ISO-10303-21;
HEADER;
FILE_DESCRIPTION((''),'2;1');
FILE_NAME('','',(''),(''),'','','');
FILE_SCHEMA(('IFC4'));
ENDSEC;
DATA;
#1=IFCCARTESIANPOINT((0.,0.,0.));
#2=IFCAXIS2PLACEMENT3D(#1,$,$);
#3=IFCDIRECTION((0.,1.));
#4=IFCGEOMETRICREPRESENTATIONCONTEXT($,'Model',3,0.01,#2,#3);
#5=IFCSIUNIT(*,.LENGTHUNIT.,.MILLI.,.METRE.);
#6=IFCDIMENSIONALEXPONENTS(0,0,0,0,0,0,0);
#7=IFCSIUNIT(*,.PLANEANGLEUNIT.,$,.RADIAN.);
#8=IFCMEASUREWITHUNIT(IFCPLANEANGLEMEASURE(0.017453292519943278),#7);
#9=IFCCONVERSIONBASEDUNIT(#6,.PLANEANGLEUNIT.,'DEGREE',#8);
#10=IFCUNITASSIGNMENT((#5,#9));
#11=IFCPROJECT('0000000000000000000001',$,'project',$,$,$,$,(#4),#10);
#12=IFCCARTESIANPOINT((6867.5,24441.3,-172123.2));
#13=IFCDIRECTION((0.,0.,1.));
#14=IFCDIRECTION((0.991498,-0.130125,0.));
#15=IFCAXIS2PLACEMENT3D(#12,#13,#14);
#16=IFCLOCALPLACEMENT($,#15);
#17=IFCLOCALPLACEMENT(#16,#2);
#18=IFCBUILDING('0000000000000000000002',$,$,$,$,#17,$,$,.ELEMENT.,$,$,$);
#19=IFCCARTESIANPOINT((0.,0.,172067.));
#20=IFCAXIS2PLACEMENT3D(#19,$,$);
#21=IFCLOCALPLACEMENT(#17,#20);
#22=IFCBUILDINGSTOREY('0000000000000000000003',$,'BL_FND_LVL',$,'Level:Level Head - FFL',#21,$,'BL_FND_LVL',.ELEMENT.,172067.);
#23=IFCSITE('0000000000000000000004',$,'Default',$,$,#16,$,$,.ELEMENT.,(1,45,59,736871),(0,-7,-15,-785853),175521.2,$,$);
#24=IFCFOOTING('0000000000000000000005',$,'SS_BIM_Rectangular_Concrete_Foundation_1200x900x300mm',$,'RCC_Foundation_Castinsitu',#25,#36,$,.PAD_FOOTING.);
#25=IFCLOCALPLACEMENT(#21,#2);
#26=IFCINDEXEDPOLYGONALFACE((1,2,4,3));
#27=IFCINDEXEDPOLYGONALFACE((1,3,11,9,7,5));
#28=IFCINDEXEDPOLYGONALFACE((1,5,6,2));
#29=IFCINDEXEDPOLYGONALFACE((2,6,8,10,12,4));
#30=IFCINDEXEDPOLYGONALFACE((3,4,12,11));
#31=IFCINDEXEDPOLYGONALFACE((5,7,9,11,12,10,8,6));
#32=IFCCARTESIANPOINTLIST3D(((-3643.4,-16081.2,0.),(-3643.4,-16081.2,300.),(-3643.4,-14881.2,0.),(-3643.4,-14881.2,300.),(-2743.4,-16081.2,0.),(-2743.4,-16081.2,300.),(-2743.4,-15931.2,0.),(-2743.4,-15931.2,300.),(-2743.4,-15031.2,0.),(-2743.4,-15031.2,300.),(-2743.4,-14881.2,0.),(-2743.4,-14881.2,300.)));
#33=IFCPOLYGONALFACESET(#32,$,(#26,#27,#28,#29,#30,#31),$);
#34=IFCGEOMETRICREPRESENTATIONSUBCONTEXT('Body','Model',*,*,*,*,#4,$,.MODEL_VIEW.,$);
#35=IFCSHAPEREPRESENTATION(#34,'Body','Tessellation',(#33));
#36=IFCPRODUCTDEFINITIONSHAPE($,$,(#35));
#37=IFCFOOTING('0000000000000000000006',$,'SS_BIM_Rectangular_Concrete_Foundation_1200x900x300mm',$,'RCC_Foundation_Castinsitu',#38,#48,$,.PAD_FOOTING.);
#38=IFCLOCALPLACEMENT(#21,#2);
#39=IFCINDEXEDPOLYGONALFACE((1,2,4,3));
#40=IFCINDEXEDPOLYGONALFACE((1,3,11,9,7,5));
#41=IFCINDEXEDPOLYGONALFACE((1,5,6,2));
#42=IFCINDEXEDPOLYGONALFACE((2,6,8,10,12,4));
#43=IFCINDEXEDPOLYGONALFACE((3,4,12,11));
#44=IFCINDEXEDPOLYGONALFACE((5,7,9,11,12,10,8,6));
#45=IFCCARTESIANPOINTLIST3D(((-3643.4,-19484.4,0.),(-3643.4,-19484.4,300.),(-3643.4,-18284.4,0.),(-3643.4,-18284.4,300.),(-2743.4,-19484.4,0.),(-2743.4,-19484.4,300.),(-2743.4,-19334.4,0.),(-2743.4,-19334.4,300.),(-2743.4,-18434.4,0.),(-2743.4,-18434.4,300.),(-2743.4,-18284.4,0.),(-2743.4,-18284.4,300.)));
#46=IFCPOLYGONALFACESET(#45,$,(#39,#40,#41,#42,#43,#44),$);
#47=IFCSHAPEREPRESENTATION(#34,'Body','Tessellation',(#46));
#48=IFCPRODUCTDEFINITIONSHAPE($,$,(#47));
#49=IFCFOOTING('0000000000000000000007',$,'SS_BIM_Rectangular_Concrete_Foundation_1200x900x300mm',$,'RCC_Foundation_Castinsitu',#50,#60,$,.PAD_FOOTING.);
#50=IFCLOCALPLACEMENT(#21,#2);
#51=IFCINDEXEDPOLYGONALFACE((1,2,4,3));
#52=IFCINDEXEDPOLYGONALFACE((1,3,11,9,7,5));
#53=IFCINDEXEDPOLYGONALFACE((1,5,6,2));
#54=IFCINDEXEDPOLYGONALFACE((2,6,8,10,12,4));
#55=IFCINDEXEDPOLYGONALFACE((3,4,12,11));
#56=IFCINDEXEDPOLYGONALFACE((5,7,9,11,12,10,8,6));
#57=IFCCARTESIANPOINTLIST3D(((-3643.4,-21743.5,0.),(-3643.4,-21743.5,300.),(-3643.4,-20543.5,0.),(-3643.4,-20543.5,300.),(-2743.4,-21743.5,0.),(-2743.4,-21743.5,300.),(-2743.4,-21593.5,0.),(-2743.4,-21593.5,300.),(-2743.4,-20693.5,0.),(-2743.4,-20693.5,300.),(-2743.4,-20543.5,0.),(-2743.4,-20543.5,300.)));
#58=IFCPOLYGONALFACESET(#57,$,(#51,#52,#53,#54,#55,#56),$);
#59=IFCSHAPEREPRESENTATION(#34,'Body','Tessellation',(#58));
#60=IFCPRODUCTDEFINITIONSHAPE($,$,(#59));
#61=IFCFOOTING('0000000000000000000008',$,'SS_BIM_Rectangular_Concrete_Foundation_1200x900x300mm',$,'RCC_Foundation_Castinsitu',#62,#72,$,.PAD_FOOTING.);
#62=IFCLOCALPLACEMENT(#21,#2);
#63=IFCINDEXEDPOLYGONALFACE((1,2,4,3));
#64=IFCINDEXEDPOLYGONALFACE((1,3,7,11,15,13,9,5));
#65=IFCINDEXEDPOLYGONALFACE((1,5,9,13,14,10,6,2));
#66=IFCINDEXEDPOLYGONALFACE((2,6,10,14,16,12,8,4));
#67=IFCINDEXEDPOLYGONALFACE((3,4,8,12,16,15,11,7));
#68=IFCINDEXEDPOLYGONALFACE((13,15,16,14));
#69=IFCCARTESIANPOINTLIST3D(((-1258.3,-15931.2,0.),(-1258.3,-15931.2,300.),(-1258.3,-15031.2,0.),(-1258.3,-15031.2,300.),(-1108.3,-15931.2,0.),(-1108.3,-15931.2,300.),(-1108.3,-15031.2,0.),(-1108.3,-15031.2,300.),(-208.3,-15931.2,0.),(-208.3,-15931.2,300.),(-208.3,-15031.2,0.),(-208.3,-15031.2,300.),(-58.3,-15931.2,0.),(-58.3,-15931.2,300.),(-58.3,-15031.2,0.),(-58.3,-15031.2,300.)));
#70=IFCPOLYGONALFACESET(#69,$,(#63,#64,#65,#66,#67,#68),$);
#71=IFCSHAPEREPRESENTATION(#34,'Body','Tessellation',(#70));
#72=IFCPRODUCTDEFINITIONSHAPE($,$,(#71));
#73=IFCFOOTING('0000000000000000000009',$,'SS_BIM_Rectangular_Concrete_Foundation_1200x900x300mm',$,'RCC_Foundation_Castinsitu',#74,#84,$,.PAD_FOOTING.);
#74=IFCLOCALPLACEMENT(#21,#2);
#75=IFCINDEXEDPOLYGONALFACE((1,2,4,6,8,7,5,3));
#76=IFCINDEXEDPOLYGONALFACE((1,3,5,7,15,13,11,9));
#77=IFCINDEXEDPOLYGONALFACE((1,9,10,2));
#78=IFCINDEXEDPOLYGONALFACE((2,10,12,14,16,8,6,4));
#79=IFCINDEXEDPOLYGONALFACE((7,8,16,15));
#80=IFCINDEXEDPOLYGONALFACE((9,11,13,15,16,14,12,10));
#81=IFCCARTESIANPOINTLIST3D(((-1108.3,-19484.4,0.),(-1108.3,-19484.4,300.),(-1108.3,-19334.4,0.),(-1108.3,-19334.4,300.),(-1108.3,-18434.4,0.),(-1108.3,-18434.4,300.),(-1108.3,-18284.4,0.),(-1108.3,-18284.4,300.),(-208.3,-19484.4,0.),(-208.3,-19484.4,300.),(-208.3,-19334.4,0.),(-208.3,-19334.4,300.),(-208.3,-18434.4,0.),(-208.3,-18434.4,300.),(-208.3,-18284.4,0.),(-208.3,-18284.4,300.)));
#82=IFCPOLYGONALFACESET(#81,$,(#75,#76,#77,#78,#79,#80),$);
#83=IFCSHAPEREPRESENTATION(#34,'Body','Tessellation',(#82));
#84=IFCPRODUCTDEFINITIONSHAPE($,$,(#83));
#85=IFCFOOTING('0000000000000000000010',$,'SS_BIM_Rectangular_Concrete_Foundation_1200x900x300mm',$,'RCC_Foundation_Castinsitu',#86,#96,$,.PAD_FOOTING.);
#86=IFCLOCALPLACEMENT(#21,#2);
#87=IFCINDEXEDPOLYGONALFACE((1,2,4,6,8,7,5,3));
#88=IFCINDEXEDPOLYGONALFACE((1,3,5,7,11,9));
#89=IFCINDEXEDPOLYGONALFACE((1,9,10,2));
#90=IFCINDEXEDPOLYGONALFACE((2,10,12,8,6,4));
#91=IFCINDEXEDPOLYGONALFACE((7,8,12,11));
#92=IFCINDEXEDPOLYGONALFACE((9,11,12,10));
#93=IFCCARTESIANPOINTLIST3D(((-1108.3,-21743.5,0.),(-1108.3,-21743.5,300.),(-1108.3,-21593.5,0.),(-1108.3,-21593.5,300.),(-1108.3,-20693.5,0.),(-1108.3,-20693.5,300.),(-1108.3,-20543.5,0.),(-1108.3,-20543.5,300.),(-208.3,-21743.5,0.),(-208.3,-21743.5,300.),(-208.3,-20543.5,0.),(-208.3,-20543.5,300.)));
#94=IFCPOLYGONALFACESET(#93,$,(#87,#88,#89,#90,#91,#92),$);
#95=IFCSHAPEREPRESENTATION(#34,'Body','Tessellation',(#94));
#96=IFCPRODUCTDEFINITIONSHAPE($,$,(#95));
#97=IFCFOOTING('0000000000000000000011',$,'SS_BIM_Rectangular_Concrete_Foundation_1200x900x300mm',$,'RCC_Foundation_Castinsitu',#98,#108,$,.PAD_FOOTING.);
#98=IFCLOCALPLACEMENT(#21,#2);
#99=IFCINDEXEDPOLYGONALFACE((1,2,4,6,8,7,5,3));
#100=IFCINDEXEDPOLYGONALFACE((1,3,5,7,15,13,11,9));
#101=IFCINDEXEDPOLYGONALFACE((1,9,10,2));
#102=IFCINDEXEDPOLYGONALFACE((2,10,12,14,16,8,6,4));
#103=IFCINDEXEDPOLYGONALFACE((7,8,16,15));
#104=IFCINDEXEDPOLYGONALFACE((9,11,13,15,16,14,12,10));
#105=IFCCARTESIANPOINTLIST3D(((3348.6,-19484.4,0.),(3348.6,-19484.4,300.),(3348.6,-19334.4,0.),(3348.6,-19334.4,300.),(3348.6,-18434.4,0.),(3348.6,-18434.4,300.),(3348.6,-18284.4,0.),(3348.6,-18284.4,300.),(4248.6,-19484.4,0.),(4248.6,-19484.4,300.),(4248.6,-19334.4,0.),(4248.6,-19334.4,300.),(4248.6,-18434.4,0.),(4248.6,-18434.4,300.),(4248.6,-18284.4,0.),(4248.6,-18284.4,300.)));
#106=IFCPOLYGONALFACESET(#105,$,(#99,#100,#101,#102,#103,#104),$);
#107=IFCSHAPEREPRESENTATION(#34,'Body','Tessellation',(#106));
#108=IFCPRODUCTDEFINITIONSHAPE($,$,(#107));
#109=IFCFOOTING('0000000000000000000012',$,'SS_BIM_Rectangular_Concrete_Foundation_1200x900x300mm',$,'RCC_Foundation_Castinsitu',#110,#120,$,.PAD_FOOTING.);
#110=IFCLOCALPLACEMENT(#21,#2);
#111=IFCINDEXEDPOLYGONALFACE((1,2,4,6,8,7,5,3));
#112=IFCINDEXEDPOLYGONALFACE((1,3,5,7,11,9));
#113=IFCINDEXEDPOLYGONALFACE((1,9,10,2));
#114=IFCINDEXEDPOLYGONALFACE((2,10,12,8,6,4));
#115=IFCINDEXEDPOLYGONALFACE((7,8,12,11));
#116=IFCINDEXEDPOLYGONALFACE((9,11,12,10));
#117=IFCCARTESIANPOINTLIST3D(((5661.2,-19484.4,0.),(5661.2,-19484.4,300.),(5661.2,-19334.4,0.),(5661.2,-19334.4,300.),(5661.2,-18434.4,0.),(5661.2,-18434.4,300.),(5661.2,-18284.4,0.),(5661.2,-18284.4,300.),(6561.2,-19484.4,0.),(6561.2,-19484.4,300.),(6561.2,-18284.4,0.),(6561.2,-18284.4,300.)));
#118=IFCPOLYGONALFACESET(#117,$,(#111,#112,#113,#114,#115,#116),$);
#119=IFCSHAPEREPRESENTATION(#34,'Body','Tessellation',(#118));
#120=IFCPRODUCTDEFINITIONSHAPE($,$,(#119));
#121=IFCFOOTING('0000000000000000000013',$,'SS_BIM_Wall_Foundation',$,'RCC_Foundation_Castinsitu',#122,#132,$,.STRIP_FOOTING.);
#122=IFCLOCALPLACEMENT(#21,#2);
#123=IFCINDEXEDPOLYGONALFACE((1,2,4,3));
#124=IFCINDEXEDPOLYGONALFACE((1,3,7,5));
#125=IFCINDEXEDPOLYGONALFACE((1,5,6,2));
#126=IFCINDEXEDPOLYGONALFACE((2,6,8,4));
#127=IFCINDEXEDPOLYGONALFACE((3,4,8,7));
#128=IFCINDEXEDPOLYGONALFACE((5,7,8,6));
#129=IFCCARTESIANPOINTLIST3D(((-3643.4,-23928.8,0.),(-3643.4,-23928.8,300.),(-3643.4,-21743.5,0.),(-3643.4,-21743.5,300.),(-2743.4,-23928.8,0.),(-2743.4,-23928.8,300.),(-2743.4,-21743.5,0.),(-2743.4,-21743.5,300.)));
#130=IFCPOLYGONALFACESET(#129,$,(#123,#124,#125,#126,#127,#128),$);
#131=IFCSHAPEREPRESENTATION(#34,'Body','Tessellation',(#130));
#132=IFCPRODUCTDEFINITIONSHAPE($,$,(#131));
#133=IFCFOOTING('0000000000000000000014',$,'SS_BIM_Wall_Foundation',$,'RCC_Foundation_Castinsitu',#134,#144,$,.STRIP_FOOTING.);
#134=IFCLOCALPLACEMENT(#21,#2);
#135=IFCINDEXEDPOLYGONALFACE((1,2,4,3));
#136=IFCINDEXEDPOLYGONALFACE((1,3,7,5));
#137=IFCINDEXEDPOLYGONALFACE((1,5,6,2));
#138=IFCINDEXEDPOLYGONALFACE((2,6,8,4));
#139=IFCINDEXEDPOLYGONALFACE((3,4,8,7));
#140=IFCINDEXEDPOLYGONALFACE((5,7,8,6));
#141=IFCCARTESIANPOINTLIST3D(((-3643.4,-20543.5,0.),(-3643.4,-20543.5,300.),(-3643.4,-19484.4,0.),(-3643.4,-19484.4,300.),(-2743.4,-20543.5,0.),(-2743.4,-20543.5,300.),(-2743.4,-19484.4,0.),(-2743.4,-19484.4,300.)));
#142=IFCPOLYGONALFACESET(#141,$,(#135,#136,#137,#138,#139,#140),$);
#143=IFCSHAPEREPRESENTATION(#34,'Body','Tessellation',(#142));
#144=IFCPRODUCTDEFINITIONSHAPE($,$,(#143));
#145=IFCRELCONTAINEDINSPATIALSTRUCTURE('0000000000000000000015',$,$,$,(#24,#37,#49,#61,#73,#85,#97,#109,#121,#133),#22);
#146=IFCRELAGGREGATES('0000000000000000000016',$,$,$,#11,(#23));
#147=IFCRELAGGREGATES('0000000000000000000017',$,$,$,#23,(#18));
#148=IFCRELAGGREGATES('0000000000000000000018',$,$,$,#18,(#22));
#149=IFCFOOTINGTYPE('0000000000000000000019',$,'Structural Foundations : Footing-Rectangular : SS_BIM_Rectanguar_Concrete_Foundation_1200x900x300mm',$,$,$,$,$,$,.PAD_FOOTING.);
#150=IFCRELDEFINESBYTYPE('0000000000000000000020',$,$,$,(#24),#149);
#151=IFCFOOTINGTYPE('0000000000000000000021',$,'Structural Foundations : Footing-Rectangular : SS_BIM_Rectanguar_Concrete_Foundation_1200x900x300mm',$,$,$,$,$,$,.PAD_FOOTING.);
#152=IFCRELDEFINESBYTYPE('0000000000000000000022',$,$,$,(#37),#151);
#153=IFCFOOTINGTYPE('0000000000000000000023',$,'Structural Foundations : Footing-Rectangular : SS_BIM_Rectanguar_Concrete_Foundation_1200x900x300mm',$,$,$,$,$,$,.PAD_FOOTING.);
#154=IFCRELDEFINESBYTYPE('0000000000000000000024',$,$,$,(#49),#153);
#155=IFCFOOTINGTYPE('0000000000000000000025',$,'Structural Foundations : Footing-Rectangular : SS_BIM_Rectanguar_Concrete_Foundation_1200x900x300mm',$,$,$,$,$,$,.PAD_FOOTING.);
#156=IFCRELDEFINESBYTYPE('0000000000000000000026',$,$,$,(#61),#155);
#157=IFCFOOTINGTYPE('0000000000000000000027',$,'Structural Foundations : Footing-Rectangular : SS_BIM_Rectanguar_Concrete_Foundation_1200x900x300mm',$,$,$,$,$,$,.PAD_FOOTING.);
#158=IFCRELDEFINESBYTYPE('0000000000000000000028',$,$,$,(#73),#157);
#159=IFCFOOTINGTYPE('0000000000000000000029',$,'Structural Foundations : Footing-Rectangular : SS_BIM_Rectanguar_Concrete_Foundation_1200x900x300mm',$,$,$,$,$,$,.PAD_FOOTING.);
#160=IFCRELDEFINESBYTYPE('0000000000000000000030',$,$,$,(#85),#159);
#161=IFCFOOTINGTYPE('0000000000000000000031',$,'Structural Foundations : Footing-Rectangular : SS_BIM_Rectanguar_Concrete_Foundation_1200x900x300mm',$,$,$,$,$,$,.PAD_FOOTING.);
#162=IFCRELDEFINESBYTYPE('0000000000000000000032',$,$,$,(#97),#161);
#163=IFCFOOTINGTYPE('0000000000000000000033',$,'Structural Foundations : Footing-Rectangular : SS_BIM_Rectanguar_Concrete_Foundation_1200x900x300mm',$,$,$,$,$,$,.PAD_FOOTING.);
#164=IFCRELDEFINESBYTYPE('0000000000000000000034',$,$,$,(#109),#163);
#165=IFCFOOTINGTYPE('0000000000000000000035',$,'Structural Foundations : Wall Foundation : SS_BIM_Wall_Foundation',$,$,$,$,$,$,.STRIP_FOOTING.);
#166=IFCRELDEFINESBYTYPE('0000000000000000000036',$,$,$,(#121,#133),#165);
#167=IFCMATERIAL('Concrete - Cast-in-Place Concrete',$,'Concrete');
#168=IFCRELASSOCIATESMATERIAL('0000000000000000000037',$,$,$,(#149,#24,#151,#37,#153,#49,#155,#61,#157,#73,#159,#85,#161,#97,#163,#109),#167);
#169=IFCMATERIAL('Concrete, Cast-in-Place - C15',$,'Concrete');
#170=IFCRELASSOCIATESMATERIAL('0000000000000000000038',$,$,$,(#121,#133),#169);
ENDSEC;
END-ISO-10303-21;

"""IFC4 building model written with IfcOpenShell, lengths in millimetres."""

from ifc_helpers import new_model, entity, si_unit, converted_unit, direction, frame, origin, place, context, subcontext, project, spatial, indexed_curve, outline, extrude, source, transform, mapped, material, type_object, type_shapes, element, save


model = new_model("IFC4")

# Units and contexts
model_context = context("Model", 3, precision=0.01, world=origin(), true_north=direction((0.0, 1.0)))
body_context = subcontext(model_context, "Body", "Model", "MODEL_VIEW")
ifc_project = project(units=[si_unit("LENGTHUNIT", "METRE", prefix="MILLI"), converted_unit("PLANEANGLEUNIT", "DEGREE", entity("IfcPlaneAngleMeasure", 0.017453292519943278), si_unit("PLANEANGLEUNIT", "RADIAN"), dimensions=[0, 0, 0, 0, 0, 0, 0])], contexts=[model_context])

# Site, building, storey
site_placement = place(None, frame((6867.5, 24441.3, -172123.2), z_axis=(0.0, 0.0, 1.0), x_axis=(0.991498, -0.130125, 0.0)))
site = spatial("IfcSite", under=ifc_project, at=site_placement, Name="Default", CompositionType="ELEMENT", RefLatitude=(1, 45, 59, 736871), RefLongitude=(0, -7, -15, -785853), RefElevation=175521.2)
building_placement = place(site_placement, origin())
building = spatial("IfcBuilding", under=site, at=building_placement, CompositionType="ELEMENT")
storey_placement = place(building_placement, frame((0.0, 0.0, 172067.0)))
storey = spatial("IfcBuildingStorey", under=building, at=storey_placement, Name="BL_FND_LVL", ObjectType="Level:Level Head - FFL", LongName="BL_FND_LVL", CompositionType="ELEMENT", Elevation=172067.0)

# Footings
ifc_material_1 = material(Name="Concrete - Cast-in-Place Concrete", Category="Concrete")
footing_type_1 = type_object("IfcFootingType", Name="Structural Foundations : Footing-Rectangular : SS_BIM_Rectanguar_Concrete_Foundation_1200x900x300mm", PredefinedType="PAD_FOOTING", material=ifc_material_1)
shared_shape_1 = source(origin(), body_context, "Body", "SweptSolid", [
    extrude(outline(indexed_curve([(-300.0, -600.0), (600.0, -600.0), (600.0, 600.0), (-300.0, 600.0), (-300.0, 450.0), (-300.0, -450.0), (-300.0, -600.0)], self_intersect=False)), frame((-3043.4, -15481.2, 172067.0), z_axis=(0.0, 0.0, 1.0), x_axis=(-1.0, 0.0, 0.0)), (0.0, 0.0, 1.0), 300.0),
])
type_shapes(footing_type_1, [shared_shape_1])
footing_1_placement = place(storey_placement, frame((0.0, 0.0, -172067.0)))
element("IfcFooting", 1, at=footing_1_placement, inside=storey, type_object=footing_type_1, material=ifc_material_1, Name="SS_BIM_Rectangular_Concrete_Foundation_1200x900x300mm", ObjectType="RCC_Foundation_Castinsitu", PredefinedType="PAD_FOOTING", context=body_context, shape_type="MappedRepresentation", body=[
    mapped(shared_shape_1, transform((0.0, 0.0, 0.0), scale=1.0)),
])
footing_type_2 = type_object("IfcFootingType", Name="Structural Foundations : Footing-Rectangular : SS_BIM_Rectanguar_Concrete_Foundation_1200x900x300mm", PredefinedType="PAD_FOOTING", material=ifc_material_1)
shared_shape_2 = source(origin(), body_context, "Body", "SweptSolid", [
    extrude(outline(indexed_curve([(-300.0, -600.0), (600.0, -600.0), (600.0, 600.0), (-300.0, 600.0), (-300.0, 450.0), (-300.0, -450.0), (-300.0, -600.0)], self_intersect=False)), frame((-3043.4, -18884.4, 172067.0), z_axis=(0.0, 0.0, 1.0), x_axis=(-1.0, 0.0, 0.0)), (0.0, 0.0, 1.0), 300.0),
])
type_shapes(footing_type_2, [shared_shape_2])
footing_2_placement = place(storey_placement, frame((0.0, 0.0, -172067.0)))
element("IfcFooting", 2, at=footing_2_placement, inside=storey, type_object=footing_type_2, material=ifc_material_1, Name="SS_BIM_Rectangular_Concrete_Foundation_1200x900x300mm", ObjectType="RCC_Foundation_Castinsitu", PredefinedType="PAD_FOOTING", context=body_context, shape_type="MappedRepresentation", body=[
    mapped(shared_shape_2, transform((0.0, 0.0, 0.0), scale=1.0)),
])
footing_type_3 = type_object("IfcFootingType", Name="Structural Foundations : Footing-Rectangular : SS_BIM_Rectanguar_Concrete_Foundation_1200x900x300mm", PredefinedType="PAD_FOOTING", material=ifc_material_1)
shared_shape_3 = source(origin(), body_context, "Body", "SweptSolid", [
    extrude(outline(indexed_curve([(-300.0, -600.0), (600.0, -600.0), (600.0, 600.0), (-300.0, 600.0), (-300.0, 450.0), (-300.0, -450.0), (-300.0, -600.0)], self_intersect=False)), frame((-3043.4, -21143.5, 172067.0), z_axis=(0.0, 0.0, 1.0), x_axis=(-1.0, 0.0, 0.0)), (0.0, 0.0, 1.0), 300.0),
])
type_shapes(footing_type_3, [shared_shape_3])
footing_3_placement = place(storey_placement, frame((0.0, 0.0, -172067.0)))
element("IfcFooting", 3, at=footing_3_placement, inside=storey, type_object=footing_type_3, material=ifc_material_1, Name="SS_BIM_Rectangular_Concrete_Foundation_1200x900x300mm", ObjectType="RCC_Foundation_Castinsitu", PredefinedType="PAD_FOOTING", context=body_context, shape_type="MappedRepresentation", body=[
    mapped(shared_shape_3, transform((0.0, 0.0, 0.0), scale=1.0)),
])
footing_type_4 = type_object("IfcFootingType", Name="Structural Foundations : Footing-Rectangular : SS_BIM_Rectanguar_Concrete_Foundation_1200x900x300mm", PredefinedType="PAD_FOOTING", material=ifc_material_1)
shared_shape_4 = source(origin(), body_context, "Body", "SweptSolid", [
    extrude(outline(indexed_curve([(-450.0, -600.0), (450.0, -600.0), (450.0, -450.0), (450.0, 450.0), (450.0, 600.0), (-450.0, 600.0), (-450.0, 450.0), (-450.0, -450.0), (-450.0, -600.0)], self_intersect=False)), frame((-658.3, -15481.2, 172067.0), z_axis=(0.0, 0.0, 1.0), x_axis=(0.0, -1.0, 0.0)), (0.0, 0.0, 1.0), 300.0),
])
type_shapes(footing_type_4, [shared_shape_4])
footing_4_placement = place(storey_placement, frame((0.0, 0.0, -172067.0)))
element("IfcFooting", 4, at=footing_4_placement, inside=storey, type_object=footing_type_4, material=ifc_material_1, Name="SS_BIM_Rectangular_Concrete_Foundation_1200x900x300mm", ObjectType="RCC_Foundation_Castinsitu", PredefinedType="PAD_FOOTING", context=body_context, shape_type="MappedRepresentation", body=[
    mapped(shared_shape_4, transform((0.0, 0.0, 0.0), scale=1.0)),
])
footing_type_5 = type_object("IfcFootingType", Name="Structural Foundations : Footing-Rectangular : SS_BIM_Rectanguar_Concrete_Foundation_1200x900x300mm", PredefinedType="PAD_FOOTING", material=ifc_material_1)
shared_shape_5 = source(origin(), body_context, "Body", "SweptSolid", [
    extrude(outline(indexed_curve([(-450.0, -600.0), (450.0, -600.0), (450.0, -450.0), (450.0, 450.0), (450.0, 600.0), (-450.0, 600.0), (-450.0, 450.0), (-450.0, -450.0), (-450.0, -600.0)], self_intersect=False)), frame((-658.3, -18884.4, 172067.0), z_axis=(0.0, 0.0, 1.0), x_axis=(-1.0, 0.0, 0.0)), (0.0, 0.0, 1.0), 300.0),
])
type_shapes(footing_type_5, [shared_shape_5])
footing_5_placement = place(storey_placement, frame((0.0, 0.0, -172067.0)))
element("IfcFooting", 5, at=footing_5_placement, inside=storey, type_object=footing_type_5, material=ifc_material_1, Name="SS_BIM_Rectangular_Concrete_Foundation_1200x900x300mm", ObjectType="RCC_Foundation_Castinsitu", PredefinedType="PAD_FOOTING", context=body_context, shape_type="MappedRepresentation", body=[
    mapped(shared_shape_5, transform((0.0, 0.0, 0.0), scale=1.0)),
])
footing_type_6 = type_object("IfcFootingType", Name="Structural Foundations : Footing-Rectangular : SS_BIM_Rectanguar_Concrete_Foundation_1200x900x300mm", PredefinedType="PAD_FOOTING", material=ifc_material_1)
shared_shape_6 = source(origin(), body_context, "Body", "SweptSolid", [
    extrude(outline(indexed_curve([(-600.0, -600.0), (300.0, -600.0), (300.0, -450.0), (300.0, 450.0), (300.0, 600.0), (-600.0, 600.0), (-600.0, -600.0)], self_intersect=False)), frame((-808.3, -21143.5, 172067.0), z_axis=(0.0, 0.0, 1.0), x_axis=(-1.0, 0.0, 0.0)), (0.0, 0.0, 1.0), 300.0),
])
type_shapes(footing_type_6, [shared_shape_6])
footing_6_placement = place(storey_placement, frame((0.0, 0.0, -172067.0)))
element("IfcFooting", 6, at=footing_6_placement, inside=storey, type_object=footing_type_6, material=ifc_material_1, Name="SS_BIM_Rectangular_Concrete_Foundation_1200x900x300mm", ObjectType="RCC_Foundation_Castinsitu", PredefinedType="PAD_FOOTING", context=body_context, shape_type="MappedRepresentation", body=[
    mapped(shared_shape_6, transform((0.0, 0.0, 0.0), scale=1.0)),
])
footing_type_7 = type_object("IfcFootingType", Name="Structural Foundations : Footing-Rectangular : SS_BIM_Rectanguar_Concrete_Foundation_1200x900x300mm", PredefinedType="PAD_FOOTING", material=ifc_material_1)
shared_shape_7 = source(origin(), body_context, "Body", "SweptSolid", [
    extrude(outline(indexed_curve([(-450.0, -600.0), (450.0, -600.0), (450.0, -450.0), (450.0, 450.0), (450.0, 600.0), (-450.0, 600.0), (-450.0, 450.0), (-450.0, -450.0), (-450.0, -600.0)], self_intersect=False)), frame((3798.6, -18884.4, 172067.0), z_axis=(0.0, 0.0, 1.0), x_axis=(-1.0, 0.0, 0.0)), (0.0, 0.0, 1.0), 300.0),
])
type_shapes(footing_type_7, [shared_shape_7])
footing_7_placement = place(storey_placement, frame((0.0, 0.0, -172067.0)))
element("IfcFooting", 7, at=footing_7_placement, inside=storey, type_object=footing_type_7, material=ifc_material_1, Name="SS_BIM_Rectangular_Concrete_Foundation_1200x900x300mm", ObjectType="RCC_Foundation_Castinsitu", PredefinedType="PAD_FOOTING", context=body_context, shape_type="MappedRepresentation", body=[
    mapped(shared_shape_7, transform((0.0, 0.0, 0.0), scale=1.0)),
])
footing_type_8 = type_object("IfcFootingType", Name="Structural Foundations : Footing-Rectangular : SS_BIM_Rectanguar_Concrete_Foundation_1200x900x300mm", PredefinedType="PAD_FOOTING", material=ifc_material_1)
shared_shape_8 = source(origin(), body_context, "Body", "SweptSolid", [
    extrude(outline(indexed_curve([(-600.0, -600.0), (300.0, -600.0), (300.0, -450.0), (300.0, 450.0), (300.0, 600.0), (-600.0, 600.0), (-600.0, -600.0)], self_intersect=False)), frame((5961.2, -18884.4, 172067.0), z_axis=(0.0, 0.0, 1.0), x_axis=(-1.0, 0.0, 0.0)), (0.0, 0.0, 1.0), 300.0),
])
type_shapes(footing_type_8, [shared_shape_8])
footing_8_placement = place(storey_placement, frame((0.0, 0.0, -172067.0)))
element("IfcFooting", 8, at=footing_8_placement, inside=storey, type_object=footing_type_8, material=ifc_material_1, Name="SS_BIM_Rectangular_Concrete_Foundation_1200x900x300mm", ObjectType="RCC_Foundation_Castinsitu", PredefinedType="PAD_FOOTING", context=body_context, shape_type="MappedRepresentation", body=[
    mapped(shared_shape_8, transform((0.0, 0.0, 0.0), scale=1.0)),
])
ifc_material_2 = material(Name="Concrete, Cast-in-Place - C15", Category="Concrete")
footing_type_9 = type_object("IfcFootingType", Name="Structural Foundations : Wall Foundation : SS_BIM_Wall_Foundation", PredefinedType="STRIP_FOOTING")
footing_9_placement = place(storey_placement, origin())
element("IfcFooting", 9, at=footing_9_placement, inside=storey, type_object=footing_type_9, material=ifc_material_2, Name="SS_BIM_Wall_Foundation", ObjectType="RCC_Foundation_Castinsitu", PredefinedType="STRIP_FOOTING", context=body_context, shape_type="SweptSolid", body=[
    extrude(outline(indexed_curve([(-1092.7, -450.0), (1092.7, -450.0), (1092.7, 450.0), (-1092.7, 450.0), (-1092.7, -450.0)], self_intersect=False)), frame((-3193.4, -22836.1, 0.0), z_axis=(0.0, 0.0, 1.0), x_axis=(0.0, 1.0, 0.0)), (0.0, 0.0, 1.0), 300.0),
])
footing_10_placement = place(storey_placement, origin())
element("IfcFooting", 10, at=footing_10_placement, inside=storey, type_object=footing_type_9, material=ifc_material_2, Name="SS_BIM_Wall_Foundation", ObjectType="RCC_Foundation_Castinsitu", PredefinedType="STRIP_FOOTING", context=body_context, shape_type="SweptSolid", body=[
    extrude(outline(indexed_curve([(-529.6, -450.0), (529.6, -450.0), (529.6, 450.0), (-529.6, 450.0), (-529.6, -450.0)], self_intersect=False)), frame((-3193.4, -20013.9, 0.0), z_axis=(0.0, 0.0, 1.0), x_axis=(0.0, -1.0, 0.0)), (0.0, 0.0, 1.0), 300.0),
])

save(model, "model.ifc")
